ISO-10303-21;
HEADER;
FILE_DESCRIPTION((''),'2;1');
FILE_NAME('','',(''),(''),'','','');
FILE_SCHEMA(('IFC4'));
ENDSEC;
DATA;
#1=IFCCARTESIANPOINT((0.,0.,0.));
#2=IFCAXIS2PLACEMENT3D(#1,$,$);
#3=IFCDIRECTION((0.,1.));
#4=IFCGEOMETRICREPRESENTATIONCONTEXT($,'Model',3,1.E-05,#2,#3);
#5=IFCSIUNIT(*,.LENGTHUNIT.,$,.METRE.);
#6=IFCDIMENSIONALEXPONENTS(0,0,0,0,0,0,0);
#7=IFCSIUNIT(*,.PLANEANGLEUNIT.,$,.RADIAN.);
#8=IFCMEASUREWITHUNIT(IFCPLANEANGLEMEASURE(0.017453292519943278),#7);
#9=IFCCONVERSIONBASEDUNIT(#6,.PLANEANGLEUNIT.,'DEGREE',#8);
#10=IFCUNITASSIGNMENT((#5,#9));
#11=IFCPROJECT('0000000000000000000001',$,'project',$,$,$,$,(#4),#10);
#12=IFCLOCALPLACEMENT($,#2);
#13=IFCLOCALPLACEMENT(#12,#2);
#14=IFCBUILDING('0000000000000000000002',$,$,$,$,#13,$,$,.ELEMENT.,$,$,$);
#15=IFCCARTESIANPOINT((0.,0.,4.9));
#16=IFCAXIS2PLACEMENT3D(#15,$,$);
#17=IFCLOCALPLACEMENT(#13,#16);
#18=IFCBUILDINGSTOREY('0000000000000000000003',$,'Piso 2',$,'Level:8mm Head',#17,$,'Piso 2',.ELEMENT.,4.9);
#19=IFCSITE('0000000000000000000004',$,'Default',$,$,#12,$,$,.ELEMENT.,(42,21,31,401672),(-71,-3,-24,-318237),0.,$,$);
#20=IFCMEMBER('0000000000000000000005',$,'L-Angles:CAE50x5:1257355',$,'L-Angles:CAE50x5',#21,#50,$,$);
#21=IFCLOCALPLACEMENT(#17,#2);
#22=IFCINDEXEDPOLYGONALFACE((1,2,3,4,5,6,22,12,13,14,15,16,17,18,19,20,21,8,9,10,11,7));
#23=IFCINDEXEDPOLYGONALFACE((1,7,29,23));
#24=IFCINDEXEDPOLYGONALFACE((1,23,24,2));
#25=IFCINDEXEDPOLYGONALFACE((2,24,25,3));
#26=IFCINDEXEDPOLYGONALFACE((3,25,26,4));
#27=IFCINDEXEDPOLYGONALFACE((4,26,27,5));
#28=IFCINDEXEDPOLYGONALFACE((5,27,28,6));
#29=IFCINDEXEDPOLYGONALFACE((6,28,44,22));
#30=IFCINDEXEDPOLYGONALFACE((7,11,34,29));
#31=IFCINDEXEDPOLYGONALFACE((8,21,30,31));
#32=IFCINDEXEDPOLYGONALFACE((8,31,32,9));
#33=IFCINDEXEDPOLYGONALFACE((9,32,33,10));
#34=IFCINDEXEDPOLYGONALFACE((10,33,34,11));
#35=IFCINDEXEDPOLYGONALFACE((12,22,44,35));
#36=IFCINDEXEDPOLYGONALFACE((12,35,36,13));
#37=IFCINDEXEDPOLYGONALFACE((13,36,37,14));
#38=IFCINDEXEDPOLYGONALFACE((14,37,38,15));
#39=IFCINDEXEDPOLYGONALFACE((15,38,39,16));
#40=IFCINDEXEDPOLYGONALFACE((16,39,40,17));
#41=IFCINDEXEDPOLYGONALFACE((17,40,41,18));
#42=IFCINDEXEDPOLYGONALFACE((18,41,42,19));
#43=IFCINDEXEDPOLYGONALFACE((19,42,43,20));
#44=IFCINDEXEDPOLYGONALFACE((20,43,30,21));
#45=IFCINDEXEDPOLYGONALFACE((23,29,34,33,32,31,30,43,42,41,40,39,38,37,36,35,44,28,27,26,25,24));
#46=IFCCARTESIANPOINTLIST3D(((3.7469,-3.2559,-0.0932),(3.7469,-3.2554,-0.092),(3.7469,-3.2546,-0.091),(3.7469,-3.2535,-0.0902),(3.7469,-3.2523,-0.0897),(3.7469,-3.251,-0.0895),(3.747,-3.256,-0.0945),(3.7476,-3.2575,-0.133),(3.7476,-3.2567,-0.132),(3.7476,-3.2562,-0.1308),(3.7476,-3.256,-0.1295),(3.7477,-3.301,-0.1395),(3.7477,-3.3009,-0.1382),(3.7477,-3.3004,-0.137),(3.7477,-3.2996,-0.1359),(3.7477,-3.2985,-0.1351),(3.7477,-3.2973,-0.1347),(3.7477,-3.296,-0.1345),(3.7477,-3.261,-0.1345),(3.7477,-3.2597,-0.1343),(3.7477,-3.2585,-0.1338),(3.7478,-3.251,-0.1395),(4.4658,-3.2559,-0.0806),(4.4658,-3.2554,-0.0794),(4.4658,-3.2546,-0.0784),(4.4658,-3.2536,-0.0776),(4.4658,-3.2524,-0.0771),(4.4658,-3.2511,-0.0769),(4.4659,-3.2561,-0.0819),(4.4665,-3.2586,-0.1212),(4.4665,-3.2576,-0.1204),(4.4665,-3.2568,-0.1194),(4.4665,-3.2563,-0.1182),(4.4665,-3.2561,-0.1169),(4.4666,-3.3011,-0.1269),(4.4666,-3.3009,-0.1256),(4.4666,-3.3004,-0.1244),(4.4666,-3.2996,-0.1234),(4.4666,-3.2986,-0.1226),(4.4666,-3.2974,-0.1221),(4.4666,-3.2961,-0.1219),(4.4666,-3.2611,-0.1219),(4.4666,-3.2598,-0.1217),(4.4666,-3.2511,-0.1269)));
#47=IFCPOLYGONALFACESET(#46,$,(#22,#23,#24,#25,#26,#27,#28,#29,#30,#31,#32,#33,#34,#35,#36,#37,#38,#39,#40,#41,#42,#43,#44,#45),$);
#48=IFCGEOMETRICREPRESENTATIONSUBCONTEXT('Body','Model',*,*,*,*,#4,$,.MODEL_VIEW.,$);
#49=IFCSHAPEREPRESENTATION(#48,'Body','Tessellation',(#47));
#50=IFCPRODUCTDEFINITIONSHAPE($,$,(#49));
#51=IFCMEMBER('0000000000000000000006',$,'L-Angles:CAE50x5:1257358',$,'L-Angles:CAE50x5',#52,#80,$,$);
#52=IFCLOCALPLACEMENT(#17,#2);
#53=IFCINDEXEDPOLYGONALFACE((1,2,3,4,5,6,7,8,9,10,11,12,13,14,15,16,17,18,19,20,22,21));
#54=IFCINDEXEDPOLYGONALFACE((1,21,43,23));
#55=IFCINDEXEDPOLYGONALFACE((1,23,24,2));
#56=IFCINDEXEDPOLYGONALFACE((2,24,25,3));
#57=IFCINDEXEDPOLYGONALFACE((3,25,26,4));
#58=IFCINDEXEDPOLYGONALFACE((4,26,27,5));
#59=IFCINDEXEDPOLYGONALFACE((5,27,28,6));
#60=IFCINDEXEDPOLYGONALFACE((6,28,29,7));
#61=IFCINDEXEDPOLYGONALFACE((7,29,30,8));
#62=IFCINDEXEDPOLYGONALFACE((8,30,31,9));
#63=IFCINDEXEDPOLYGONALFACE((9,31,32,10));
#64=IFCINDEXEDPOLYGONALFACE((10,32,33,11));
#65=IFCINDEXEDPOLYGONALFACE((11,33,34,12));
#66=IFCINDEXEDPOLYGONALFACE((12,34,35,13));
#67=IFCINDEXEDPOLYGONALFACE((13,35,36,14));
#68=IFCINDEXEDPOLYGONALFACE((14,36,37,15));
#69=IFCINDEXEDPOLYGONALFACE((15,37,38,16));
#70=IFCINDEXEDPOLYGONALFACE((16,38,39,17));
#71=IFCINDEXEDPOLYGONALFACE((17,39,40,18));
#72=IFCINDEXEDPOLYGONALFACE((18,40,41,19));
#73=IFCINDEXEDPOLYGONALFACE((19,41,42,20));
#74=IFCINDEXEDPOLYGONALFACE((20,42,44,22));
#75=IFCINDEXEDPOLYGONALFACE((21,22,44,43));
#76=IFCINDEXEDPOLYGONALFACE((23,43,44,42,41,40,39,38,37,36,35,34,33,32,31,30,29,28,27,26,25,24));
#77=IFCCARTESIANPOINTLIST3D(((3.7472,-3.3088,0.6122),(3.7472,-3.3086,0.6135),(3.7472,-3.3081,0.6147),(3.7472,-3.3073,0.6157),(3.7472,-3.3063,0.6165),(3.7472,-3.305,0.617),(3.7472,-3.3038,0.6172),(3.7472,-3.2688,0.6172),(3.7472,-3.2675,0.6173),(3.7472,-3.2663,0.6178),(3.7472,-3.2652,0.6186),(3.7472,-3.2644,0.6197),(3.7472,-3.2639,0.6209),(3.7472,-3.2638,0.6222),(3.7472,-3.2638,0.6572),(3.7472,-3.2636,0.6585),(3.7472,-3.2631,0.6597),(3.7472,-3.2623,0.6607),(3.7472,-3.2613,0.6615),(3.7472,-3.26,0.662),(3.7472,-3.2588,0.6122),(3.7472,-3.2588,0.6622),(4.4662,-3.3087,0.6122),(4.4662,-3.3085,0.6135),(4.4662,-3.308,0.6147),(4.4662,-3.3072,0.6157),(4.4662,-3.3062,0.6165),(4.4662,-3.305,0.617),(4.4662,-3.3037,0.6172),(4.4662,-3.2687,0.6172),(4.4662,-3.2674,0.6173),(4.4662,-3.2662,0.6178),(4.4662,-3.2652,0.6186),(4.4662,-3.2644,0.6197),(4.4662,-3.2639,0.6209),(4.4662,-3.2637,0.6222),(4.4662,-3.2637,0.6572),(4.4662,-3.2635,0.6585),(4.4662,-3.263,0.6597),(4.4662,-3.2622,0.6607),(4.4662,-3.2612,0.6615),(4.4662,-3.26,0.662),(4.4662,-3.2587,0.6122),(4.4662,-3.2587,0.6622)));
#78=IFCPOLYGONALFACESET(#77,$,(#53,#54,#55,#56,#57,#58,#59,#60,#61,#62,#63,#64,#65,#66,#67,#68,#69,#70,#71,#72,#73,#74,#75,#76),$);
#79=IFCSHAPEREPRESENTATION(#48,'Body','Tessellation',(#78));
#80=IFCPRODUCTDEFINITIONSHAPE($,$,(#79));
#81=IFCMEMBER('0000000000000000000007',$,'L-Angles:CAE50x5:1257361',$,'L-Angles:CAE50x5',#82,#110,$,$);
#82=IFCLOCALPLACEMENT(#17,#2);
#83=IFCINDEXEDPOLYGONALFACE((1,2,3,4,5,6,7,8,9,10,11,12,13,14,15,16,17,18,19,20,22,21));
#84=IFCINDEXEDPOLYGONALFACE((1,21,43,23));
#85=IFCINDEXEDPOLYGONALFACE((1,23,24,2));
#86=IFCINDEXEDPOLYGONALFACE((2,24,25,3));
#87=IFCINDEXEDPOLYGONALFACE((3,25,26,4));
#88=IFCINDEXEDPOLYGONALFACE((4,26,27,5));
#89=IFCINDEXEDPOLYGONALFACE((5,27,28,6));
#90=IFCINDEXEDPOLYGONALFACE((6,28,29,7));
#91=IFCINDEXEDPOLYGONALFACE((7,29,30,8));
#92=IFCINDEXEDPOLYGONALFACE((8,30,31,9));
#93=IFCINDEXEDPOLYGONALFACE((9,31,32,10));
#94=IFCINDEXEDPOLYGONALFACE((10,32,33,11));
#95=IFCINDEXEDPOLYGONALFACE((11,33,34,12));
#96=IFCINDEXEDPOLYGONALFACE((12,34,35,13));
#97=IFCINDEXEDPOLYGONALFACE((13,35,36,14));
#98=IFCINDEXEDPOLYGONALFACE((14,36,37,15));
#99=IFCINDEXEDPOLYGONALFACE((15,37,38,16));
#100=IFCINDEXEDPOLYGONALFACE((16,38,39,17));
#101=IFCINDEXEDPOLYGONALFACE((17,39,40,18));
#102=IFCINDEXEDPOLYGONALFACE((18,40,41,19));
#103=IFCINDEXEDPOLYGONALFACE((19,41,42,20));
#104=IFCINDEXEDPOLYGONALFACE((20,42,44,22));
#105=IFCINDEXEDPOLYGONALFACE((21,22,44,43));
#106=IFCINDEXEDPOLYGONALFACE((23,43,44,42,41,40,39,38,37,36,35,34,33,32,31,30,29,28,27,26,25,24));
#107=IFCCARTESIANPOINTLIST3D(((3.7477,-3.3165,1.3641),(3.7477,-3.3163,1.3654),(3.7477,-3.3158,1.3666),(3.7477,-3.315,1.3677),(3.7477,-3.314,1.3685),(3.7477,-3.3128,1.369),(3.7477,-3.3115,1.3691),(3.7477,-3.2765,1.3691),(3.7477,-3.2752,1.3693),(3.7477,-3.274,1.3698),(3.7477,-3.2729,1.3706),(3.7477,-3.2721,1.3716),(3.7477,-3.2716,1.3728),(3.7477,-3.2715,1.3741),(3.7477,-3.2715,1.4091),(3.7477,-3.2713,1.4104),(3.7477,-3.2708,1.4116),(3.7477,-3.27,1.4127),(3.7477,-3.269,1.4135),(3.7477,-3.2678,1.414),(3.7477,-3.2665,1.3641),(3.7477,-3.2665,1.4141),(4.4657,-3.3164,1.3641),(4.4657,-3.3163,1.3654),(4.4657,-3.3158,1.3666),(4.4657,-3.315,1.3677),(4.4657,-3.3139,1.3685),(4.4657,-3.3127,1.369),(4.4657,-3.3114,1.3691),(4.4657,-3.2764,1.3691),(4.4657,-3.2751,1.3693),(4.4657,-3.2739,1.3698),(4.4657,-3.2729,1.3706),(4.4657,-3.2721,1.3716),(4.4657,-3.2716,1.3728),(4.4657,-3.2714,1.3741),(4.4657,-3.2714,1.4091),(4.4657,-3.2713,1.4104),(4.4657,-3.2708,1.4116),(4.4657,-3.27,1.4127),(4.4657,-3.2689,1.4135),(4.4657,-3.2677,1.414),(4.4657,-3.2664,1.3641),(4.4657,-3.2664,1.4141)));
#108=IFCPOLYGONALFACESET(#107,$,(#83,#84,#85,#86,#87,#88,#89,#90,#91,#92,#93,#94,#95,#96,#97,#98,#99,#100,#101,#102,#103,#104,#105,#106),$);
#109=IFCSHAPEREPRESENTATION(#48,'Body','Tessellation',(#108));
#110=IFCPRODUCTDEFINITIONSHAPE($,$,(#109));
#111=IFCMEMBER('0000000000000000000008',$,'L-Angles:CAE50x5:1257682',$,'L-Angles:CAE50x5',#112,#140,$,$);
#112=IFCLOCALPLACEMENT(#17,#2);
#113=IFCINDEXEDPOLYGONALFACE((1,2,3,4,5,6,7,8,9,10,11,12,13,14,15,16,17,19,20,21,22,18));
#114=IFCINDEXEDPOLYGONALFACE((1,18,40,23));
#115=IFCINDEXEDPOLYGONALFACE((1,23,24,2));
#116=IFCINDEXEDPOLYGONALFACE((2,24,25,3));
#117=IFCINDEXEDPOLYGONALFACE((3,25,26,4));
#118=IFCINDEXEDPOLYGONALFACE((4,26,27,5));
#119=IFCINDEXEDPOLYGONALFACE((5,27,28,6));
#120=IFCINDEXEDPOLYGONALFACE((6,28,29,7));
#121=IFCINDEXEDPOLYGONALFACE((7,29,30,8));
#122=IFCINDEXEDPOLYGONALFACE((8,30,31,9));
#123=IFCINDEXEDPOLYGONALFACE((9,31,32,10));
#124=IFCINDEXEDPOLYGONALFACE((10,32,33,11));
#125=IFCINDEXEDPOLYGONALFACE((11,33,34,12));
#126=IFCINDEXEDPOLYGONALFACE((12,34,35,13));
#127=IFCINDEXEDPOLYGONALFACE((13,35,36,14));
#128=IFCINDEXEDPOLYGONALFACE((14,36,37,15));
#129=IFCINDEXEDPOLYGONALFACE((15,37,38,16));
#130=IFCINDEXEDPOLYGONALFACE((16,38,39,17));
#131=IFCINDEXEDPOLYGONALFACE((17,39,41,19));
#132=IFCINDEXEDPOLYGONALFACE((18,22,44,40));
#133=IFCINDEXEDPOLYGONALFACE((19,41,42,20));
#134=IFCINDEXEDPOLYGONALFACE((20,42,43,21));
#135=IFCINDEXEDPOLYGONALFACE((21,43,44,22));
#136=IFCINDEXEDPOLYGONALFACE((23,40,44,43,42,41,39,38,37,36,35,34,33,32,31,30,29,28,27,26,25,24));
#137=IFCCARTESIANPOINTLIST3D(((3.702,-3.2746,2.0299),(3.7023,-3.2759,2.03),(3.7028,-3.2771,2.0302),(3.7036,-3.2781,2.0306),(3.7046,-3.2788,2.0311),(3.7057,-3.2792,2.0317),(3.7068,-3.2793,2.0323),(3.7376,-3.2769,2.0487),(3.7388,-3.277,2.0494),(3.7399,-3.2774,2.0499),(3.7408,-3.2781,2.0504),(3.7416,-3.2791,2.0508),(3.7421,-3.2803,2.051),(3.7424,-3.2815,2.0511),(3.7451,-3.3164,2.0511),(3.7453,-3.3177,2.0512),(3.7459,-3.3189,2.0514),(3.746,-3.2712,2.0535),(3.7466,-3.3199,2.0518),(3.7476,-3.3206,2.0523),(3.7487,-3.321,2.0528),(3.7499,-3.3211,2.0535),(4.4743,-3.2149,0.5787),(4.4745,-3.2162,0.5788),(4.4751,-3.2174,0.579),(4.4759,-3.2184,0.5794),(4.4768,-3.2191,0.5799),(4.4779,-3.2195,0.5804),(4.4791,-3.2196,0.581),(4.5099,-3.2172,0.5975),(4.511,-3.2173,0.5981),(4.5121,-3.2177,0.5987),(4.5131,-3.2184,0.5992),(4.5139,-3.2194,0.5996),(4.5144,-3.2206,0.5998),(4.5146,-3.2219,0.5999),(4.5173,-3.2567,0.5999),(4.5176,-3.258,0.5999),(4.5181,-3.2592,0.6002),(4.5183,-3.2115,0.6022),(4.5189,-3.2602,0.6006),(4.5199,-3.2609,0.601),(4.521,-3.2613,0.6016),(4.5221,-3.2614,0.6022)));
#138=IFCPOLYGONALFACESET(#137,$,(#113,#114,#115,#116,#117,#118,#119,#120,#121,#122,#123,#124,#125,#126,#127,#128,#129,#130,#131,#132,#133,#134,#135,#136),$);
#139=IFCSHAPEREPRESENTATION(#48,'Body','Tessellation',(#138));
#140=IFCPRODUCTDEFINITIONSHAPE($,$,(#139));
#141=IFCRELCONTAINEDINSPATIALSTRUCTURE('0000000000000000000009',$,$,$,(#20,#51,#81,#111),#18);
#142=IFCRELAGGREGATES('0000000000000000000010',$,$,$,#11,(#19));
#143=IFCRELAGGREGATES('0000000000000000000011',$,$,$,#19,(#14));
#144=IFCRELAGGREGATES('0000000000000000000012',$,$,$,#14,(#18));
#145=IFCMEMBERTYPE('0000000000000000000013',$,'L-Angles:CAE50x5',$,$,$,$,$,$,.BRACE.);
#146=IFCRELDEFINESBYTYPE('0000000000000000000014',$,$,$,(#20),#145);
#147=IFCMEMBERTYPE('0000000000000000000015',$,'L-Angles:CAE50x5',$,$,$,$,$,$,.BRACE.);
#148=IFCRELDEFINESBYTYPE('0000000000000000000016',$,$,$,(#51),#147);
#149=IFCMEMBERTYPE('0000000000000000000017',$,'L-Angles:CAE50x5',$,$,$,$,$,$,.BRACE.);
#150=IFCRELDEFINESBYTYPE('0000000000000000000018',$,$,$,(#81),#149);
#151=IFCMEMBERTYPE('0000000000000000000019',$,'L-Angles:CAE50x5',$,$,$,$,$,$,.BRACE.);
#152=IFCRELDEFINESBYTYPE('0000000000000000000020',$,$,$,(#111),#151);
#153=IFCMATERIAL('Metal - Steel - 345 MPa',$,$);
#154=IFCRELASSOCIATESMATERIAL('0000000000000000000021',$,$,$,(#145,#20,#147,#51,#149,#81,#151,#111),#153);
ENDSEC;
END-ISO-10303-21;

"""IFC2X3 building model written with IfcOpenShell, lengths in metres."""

from ifc_helpers import new_model, entity, si_unit, converted_unit, direction, frame, frame_2d, origin, place, context, subcontext, project, spatial, polyline, circle_curve, parameter, trimmed, segment, composite_curve, outline, extrude, source, transform, mapped, material, type_object, type_shapes, element, save


model = new_model("IFC2X3")

# Units and contexts
model_context = context("Model", 3, precision=1e-05, world=origin(), true_north=direction((0.0, 1.0)))
body_context = subcontext(model_context, "Body", "Model", "MODEL_VIEW")
ifc_project = project(units=[si_unit("LENGTHUNIT", "METRE"), converted_unit("PLANEANGLEUNIT", "DEGREE", entity("IfcPlaneAngleMeasure", 0.017453292519943278), si_unit("PLANEANGLEUNIT", "RADIAN"), dimensions=[0, 0, 0, 0, 0, 0, 0])], contexts=[model_context])

# Site, building, storey
site_placement = place(None, origin())
site = spatial("IfcSite", under=ifc_project, at=site_placement, Name="Default", CompositionType="ELEMENT", RefLatitude=(42, 21, 31, 401672), RefLongitude=(-71, -3, -24, -318237), RefElevation=0.0)
building_placement = place(site_placement, origin())
building = spatial("IfcBuilding", under=site, at=building_placement, CompositionType="ELEMENT")
storey_placement = place(building_placement, frame((0.0, 0.0, 4.9)))
storey = spatial("IfcBuildingStorey", under=building, at=storey_placement, Name="Piso 2", ObjectType="Level:8mm Head", LongName="Piso 2", CompositionType="ELEMENT", Elevation=4.9)

# Shared definitions
ifc_material_1 = material(Name="Metal - Steel - 345 MPa")

# Members
member_type_1 = type_object("IfcMemberType", Name="L-Angles:CAE50x5", PredefinedType="BRACE", material=ifc_material_1)
shared_shape_1 = source(origin(), body_context, "Body", "SweptSolid", [
    extrude(outline(composite_curve([segment(polyline([(-0.0164, -0.0164), (0.0336, -0.0164)]), True, "CONTINUOUS"), segment(trimmed(circle_curve(frame_2d((0.0286, -0.0164), x_axis=(1.0, 0.0)), 0.005), [parameter(0.0)], [parameter(90.0)], True, "PARAMETER"), True, "CONTINUOUS"), segment(polyline([(0.0286, -0.0114), (-0.0064, -0.0114)]), True, "CONTINUOUS"), segment(trimmed(circle_curve(frame_2d((-0.0064, -0.0064), x_axis=(1.0, 0.0)), 0.005), [parameter(180.0)], [parameter(270.0)], True, "PARAMETER"), False, "CONTINUOUS"), segment(polyline([(-0.0114, -0.0064), (-0.0114, 0.0286)]), True, "CONTINUOUS"), segment(trimmed(circle_curve(frame_2d((-0.0164, 0.0286), x_axis=(1.0, 0.0)), 0.005), [parameter(0.0)], [parameter(90.0)], True, "PARAMETER"), True, "CONTINUOUS"), segment(polyline([(-0.0164, 0.0336), (-0.0164, -0.0164)]), True, "CONTINUOUS")], self_intersect=False)), frame((-0.359, -0.0024, -0.0024), z_axis=(1.0, 0.0, 0.0), x_axis=(0.0, -1.0, 0.0)), (0.0, 0.0, 1.0), 0.719),
])
type_shapes(member_type_1, [shared_shape_1])
member_1_placement = place(storey_placement, frame((4.1065, -3.2651, -0.1192), z_axis=(0.000087, 1.0, 0.0), x_axis=(0.999847, -0.000087, 0.017496)))
element("IfcMember", 1, at=member_1_placement, inside=storey, type_object=member_type_1, material=ifc_material_1, Name="L-Angles:CAE50x5:1257355", ObjectType="L-Angles:CAE50x5", context=body_context, shape_type="MappedRepresentation", body=[
    mapped(shared_shape_1, transform((0.0, 0.0, 0.0), scale=1.0)),
])
member_type_2 = type_object("IfcMemberType", Name="L-Angles:CAE50x5", PredefinedType="BRACE", material=ifc_material_1)
shared_shape_2 = source(origin(), body_context, "Body", "SweptSolid", [
    extrude(outline(composite_curve([segment(polyline([(-0.0164, -0.0164), (0.0336, -0.0164)]), True, "CONTINUOUS"), segment(trimmed(circle_curve(frame_2d((0.0286, -0.0164), x_axis=(1.0, 0.0)), 0.005), [parameter(0.0)], [parameter(90.0)], True, "PARAMETER"), True, "CONTINUOUS"), segment(polyline([(0.0286, -0.0114), (-0.0064, -0.0114)]), True, "CONTINUOUS"), segment(trimmed(circle_curve(frame_2d((-0.0064, -0.0064), x_axis=(1.0, 0.0)), 0.005), [parameter(180.0)], [parameter(270.0)], True, "PARAMETER"), False, "CONTINUOUS"), segment(polyline([(-0.0114, -0.0064), (-0.0114, 0.0286)]), True, "CONTINUOUS"), segment(trimmed(circle_curve(frame_2d((-0.0164, 0.0286), x_axis=(1.0, 0.0)), 0.005), [parameter(0.0)], [parameter(90.0)], True, "PARAMETER"), True, "CONTINUOUS"), segment(polyline([(-0.0164, 0.0336), (-0.0164, -0.0164)]), True, "CONTINUOUS")], self_intersect=False)), frame((-0.3595, -0.0024, -0.0024), z_axis=(1.0, 0.0, 0.0), x_axis=(0.0, -1.0, 0.0)), (0.0, 0.0, 1.0), 0.719),
])
type_shapes(member_type_2, [shared_shape_2])
member_2_placement = place(storey_placement, frame((4.1067, -3.2727, 0.6262), z_axis=(-0.000076, 1.0, 0.0), x_axis=(1.0, 0.000076, 0.000001)))
element("IfcMember", 2, at=member_2_placement, inside=storey, type_object=member_type_2, material=ifc_material_1, Name="L-Angles:CAE50x5:1257358", ObjectType="L-Angles:CAE50x5", context=body_context, shape_type="MappedRepresentation", body=[
    mapped(shared_shape_2, transform((0.0, 0.0, 0.0), scale=1.0)),
])
member_type_3 = type_object("IfcMemberType", Name="L-Angles:CAE50x5", PredefinedType="BRACE", material=ifc_material_1)
shared_shape_3 = source(origin(), body_context, "Body", "SweptSolid", [
    extrude(outline(composite_curve([segment(polyline([(-0.0164, -0.0164), (0.0336, -0.0164)]), True, "CONTINUOUS"), segment(trimmed(circle_curve(frame_2d((0.0286, -0.0164), x_axis=(1.0, 0.0)), 0.005), [parameter(0.0)], [parameter(90.0)], True, "PARAMETER"), True, "CONTINUOUS"), segment(polyline([(0.0286, -0.0114), (-0.0064, -0.0114)]), True, "CONTINUOUS"), segment(trimmed(circle_curve(frame_2d((-0.0064, -0.0064), x_axis=(1.0, 0.0)), 0.005), [parameter(180.0)], [parameter(270.0)], True, "PARAMETER"), False, "CONTINUOUS"), segment(polyline([(-0.0114, -0.0064), (-0.0114, 0.0286)]), True, "CONTINUOUS"), segment(trimmed(circle_curve(frame_2d((-0.0164, 0.0286), x_axis=(1.0, 0.0)), 0.005), [parameter(0.0)], [parameter(90.0)], True, "PARAMETER"), True, "CONTINUOUS"), segment(polyline([(-0.0164, 0.0336), (-0.0164, -0.0164)]), True, "CONTINUOUS")], self_intersect=False)), frame((-0.359, -0.0024, -0.0024), z_axis=(1.0, 0.0, 0.0), x_axis=(0.0, -1.0, 0.0)), (0.0, 0.0, 1.0), 0.718),
])
type_shapes(member_type_3, [shared_shape_3])
member_3_placement = place(storey_placement, frame((4.1067, -3.2804, 1.3781), z_axis=(-0.000058, 1.0, 0.0), x_axis=(1.0, 0.000058, 0.000001)))
element("IfcMember", 3, at=member_3_placement, inside=storey, type_object=member_type_3, material=ifc_material_1, Name="L-Angles:CAE50x5:1257361", ObjectType="L-Angles:CAE50x5", context=body_context, shape_type="MappedRepresentation", body=[
    mapped(shared_shape_3, transform((0.0, 0.0, 0.0), scale=1.0)),
])
member_type_4 = type_object("IfcMemberType", Name="L-Angles:CAE50x5", PredefinedType="BRACE", material=ifc_material_1)
shared_shape_4 = source(origin(), body_context, "Body", "SweptSolid", [
    extrude(outline(composite_curve([segment(polyline([(-0.0164, -0.0164), (0.0336, -0.0164)]), True, "CONTINUOUS"), segment(trimmed(circle_curve(frame_2d((0.0286, -0.0164), x_axis=(1.0, 0.0)), 0.005), [parameter(0.0)], [parameter(90.0)], True, "PARAMETER"), True, "CONTINUOUS"), segment(polyline([(0.0286, -0.0114), (-0.0064, -0.0114)]), True, "CONTINUOUS"), segment(trimmed(circle_curve(frame_2d((-0.0064, -0.0064), x_axis=(1.0, 0.0)), 0.005), [parameter(180.0)], [parameter(270.0)], True, "PARAMETER"), False, "CONTINUOUS"), segment(polyline([(-0.0114, -0.0064), (-0.0114, 0.0286)]), True, "CONTINUOUS"), segment(trimmed(circle_curve(frame_2d((-0.0164, 0.0286), x_axis=(1.0, 0.0)), 0.005), [parameter(0.0)], [parameter(90.0)], True, "PARAMETER"), True, "CONTINUOUS"), segment(polyline([(-0.0164, 0.0336), (-0.0164, -0.0164)]), True, "CONTINUOUS")], self_intersect=False)), frame((-0.766, -0.0024, -0.0024), z_axis=(1.0, 0.0, 0.0), x_axis=(0.0, -1.0, 0.0)), (0.0, 0.0, 1.0), 1.645),
])
type_shapes(member_type_4, [shared_shape_4])
member_4_placement = place(storey_placement, frame((4.0944, -3.2583, 1.3711), z_axis=(0.879585, 0.067992, 0.470858), x_axis=(0.469458, 0.036289, -0.882209)))
element("IfcMember", 4, at=member_4_placement, inside=storey, type_object=member_type_4, material=ifc_material_1, Name="L-Angles:CAE50x5:1257682", ObjectType="L-Angles:CAE50x5", context=body_context, shape_type="MappedRepresentation", body=[
    mapped(shared_shape_4, transform((0.0, 0.0, 0.0), scale=1.0)),
])

save(model, "model.ifc")
